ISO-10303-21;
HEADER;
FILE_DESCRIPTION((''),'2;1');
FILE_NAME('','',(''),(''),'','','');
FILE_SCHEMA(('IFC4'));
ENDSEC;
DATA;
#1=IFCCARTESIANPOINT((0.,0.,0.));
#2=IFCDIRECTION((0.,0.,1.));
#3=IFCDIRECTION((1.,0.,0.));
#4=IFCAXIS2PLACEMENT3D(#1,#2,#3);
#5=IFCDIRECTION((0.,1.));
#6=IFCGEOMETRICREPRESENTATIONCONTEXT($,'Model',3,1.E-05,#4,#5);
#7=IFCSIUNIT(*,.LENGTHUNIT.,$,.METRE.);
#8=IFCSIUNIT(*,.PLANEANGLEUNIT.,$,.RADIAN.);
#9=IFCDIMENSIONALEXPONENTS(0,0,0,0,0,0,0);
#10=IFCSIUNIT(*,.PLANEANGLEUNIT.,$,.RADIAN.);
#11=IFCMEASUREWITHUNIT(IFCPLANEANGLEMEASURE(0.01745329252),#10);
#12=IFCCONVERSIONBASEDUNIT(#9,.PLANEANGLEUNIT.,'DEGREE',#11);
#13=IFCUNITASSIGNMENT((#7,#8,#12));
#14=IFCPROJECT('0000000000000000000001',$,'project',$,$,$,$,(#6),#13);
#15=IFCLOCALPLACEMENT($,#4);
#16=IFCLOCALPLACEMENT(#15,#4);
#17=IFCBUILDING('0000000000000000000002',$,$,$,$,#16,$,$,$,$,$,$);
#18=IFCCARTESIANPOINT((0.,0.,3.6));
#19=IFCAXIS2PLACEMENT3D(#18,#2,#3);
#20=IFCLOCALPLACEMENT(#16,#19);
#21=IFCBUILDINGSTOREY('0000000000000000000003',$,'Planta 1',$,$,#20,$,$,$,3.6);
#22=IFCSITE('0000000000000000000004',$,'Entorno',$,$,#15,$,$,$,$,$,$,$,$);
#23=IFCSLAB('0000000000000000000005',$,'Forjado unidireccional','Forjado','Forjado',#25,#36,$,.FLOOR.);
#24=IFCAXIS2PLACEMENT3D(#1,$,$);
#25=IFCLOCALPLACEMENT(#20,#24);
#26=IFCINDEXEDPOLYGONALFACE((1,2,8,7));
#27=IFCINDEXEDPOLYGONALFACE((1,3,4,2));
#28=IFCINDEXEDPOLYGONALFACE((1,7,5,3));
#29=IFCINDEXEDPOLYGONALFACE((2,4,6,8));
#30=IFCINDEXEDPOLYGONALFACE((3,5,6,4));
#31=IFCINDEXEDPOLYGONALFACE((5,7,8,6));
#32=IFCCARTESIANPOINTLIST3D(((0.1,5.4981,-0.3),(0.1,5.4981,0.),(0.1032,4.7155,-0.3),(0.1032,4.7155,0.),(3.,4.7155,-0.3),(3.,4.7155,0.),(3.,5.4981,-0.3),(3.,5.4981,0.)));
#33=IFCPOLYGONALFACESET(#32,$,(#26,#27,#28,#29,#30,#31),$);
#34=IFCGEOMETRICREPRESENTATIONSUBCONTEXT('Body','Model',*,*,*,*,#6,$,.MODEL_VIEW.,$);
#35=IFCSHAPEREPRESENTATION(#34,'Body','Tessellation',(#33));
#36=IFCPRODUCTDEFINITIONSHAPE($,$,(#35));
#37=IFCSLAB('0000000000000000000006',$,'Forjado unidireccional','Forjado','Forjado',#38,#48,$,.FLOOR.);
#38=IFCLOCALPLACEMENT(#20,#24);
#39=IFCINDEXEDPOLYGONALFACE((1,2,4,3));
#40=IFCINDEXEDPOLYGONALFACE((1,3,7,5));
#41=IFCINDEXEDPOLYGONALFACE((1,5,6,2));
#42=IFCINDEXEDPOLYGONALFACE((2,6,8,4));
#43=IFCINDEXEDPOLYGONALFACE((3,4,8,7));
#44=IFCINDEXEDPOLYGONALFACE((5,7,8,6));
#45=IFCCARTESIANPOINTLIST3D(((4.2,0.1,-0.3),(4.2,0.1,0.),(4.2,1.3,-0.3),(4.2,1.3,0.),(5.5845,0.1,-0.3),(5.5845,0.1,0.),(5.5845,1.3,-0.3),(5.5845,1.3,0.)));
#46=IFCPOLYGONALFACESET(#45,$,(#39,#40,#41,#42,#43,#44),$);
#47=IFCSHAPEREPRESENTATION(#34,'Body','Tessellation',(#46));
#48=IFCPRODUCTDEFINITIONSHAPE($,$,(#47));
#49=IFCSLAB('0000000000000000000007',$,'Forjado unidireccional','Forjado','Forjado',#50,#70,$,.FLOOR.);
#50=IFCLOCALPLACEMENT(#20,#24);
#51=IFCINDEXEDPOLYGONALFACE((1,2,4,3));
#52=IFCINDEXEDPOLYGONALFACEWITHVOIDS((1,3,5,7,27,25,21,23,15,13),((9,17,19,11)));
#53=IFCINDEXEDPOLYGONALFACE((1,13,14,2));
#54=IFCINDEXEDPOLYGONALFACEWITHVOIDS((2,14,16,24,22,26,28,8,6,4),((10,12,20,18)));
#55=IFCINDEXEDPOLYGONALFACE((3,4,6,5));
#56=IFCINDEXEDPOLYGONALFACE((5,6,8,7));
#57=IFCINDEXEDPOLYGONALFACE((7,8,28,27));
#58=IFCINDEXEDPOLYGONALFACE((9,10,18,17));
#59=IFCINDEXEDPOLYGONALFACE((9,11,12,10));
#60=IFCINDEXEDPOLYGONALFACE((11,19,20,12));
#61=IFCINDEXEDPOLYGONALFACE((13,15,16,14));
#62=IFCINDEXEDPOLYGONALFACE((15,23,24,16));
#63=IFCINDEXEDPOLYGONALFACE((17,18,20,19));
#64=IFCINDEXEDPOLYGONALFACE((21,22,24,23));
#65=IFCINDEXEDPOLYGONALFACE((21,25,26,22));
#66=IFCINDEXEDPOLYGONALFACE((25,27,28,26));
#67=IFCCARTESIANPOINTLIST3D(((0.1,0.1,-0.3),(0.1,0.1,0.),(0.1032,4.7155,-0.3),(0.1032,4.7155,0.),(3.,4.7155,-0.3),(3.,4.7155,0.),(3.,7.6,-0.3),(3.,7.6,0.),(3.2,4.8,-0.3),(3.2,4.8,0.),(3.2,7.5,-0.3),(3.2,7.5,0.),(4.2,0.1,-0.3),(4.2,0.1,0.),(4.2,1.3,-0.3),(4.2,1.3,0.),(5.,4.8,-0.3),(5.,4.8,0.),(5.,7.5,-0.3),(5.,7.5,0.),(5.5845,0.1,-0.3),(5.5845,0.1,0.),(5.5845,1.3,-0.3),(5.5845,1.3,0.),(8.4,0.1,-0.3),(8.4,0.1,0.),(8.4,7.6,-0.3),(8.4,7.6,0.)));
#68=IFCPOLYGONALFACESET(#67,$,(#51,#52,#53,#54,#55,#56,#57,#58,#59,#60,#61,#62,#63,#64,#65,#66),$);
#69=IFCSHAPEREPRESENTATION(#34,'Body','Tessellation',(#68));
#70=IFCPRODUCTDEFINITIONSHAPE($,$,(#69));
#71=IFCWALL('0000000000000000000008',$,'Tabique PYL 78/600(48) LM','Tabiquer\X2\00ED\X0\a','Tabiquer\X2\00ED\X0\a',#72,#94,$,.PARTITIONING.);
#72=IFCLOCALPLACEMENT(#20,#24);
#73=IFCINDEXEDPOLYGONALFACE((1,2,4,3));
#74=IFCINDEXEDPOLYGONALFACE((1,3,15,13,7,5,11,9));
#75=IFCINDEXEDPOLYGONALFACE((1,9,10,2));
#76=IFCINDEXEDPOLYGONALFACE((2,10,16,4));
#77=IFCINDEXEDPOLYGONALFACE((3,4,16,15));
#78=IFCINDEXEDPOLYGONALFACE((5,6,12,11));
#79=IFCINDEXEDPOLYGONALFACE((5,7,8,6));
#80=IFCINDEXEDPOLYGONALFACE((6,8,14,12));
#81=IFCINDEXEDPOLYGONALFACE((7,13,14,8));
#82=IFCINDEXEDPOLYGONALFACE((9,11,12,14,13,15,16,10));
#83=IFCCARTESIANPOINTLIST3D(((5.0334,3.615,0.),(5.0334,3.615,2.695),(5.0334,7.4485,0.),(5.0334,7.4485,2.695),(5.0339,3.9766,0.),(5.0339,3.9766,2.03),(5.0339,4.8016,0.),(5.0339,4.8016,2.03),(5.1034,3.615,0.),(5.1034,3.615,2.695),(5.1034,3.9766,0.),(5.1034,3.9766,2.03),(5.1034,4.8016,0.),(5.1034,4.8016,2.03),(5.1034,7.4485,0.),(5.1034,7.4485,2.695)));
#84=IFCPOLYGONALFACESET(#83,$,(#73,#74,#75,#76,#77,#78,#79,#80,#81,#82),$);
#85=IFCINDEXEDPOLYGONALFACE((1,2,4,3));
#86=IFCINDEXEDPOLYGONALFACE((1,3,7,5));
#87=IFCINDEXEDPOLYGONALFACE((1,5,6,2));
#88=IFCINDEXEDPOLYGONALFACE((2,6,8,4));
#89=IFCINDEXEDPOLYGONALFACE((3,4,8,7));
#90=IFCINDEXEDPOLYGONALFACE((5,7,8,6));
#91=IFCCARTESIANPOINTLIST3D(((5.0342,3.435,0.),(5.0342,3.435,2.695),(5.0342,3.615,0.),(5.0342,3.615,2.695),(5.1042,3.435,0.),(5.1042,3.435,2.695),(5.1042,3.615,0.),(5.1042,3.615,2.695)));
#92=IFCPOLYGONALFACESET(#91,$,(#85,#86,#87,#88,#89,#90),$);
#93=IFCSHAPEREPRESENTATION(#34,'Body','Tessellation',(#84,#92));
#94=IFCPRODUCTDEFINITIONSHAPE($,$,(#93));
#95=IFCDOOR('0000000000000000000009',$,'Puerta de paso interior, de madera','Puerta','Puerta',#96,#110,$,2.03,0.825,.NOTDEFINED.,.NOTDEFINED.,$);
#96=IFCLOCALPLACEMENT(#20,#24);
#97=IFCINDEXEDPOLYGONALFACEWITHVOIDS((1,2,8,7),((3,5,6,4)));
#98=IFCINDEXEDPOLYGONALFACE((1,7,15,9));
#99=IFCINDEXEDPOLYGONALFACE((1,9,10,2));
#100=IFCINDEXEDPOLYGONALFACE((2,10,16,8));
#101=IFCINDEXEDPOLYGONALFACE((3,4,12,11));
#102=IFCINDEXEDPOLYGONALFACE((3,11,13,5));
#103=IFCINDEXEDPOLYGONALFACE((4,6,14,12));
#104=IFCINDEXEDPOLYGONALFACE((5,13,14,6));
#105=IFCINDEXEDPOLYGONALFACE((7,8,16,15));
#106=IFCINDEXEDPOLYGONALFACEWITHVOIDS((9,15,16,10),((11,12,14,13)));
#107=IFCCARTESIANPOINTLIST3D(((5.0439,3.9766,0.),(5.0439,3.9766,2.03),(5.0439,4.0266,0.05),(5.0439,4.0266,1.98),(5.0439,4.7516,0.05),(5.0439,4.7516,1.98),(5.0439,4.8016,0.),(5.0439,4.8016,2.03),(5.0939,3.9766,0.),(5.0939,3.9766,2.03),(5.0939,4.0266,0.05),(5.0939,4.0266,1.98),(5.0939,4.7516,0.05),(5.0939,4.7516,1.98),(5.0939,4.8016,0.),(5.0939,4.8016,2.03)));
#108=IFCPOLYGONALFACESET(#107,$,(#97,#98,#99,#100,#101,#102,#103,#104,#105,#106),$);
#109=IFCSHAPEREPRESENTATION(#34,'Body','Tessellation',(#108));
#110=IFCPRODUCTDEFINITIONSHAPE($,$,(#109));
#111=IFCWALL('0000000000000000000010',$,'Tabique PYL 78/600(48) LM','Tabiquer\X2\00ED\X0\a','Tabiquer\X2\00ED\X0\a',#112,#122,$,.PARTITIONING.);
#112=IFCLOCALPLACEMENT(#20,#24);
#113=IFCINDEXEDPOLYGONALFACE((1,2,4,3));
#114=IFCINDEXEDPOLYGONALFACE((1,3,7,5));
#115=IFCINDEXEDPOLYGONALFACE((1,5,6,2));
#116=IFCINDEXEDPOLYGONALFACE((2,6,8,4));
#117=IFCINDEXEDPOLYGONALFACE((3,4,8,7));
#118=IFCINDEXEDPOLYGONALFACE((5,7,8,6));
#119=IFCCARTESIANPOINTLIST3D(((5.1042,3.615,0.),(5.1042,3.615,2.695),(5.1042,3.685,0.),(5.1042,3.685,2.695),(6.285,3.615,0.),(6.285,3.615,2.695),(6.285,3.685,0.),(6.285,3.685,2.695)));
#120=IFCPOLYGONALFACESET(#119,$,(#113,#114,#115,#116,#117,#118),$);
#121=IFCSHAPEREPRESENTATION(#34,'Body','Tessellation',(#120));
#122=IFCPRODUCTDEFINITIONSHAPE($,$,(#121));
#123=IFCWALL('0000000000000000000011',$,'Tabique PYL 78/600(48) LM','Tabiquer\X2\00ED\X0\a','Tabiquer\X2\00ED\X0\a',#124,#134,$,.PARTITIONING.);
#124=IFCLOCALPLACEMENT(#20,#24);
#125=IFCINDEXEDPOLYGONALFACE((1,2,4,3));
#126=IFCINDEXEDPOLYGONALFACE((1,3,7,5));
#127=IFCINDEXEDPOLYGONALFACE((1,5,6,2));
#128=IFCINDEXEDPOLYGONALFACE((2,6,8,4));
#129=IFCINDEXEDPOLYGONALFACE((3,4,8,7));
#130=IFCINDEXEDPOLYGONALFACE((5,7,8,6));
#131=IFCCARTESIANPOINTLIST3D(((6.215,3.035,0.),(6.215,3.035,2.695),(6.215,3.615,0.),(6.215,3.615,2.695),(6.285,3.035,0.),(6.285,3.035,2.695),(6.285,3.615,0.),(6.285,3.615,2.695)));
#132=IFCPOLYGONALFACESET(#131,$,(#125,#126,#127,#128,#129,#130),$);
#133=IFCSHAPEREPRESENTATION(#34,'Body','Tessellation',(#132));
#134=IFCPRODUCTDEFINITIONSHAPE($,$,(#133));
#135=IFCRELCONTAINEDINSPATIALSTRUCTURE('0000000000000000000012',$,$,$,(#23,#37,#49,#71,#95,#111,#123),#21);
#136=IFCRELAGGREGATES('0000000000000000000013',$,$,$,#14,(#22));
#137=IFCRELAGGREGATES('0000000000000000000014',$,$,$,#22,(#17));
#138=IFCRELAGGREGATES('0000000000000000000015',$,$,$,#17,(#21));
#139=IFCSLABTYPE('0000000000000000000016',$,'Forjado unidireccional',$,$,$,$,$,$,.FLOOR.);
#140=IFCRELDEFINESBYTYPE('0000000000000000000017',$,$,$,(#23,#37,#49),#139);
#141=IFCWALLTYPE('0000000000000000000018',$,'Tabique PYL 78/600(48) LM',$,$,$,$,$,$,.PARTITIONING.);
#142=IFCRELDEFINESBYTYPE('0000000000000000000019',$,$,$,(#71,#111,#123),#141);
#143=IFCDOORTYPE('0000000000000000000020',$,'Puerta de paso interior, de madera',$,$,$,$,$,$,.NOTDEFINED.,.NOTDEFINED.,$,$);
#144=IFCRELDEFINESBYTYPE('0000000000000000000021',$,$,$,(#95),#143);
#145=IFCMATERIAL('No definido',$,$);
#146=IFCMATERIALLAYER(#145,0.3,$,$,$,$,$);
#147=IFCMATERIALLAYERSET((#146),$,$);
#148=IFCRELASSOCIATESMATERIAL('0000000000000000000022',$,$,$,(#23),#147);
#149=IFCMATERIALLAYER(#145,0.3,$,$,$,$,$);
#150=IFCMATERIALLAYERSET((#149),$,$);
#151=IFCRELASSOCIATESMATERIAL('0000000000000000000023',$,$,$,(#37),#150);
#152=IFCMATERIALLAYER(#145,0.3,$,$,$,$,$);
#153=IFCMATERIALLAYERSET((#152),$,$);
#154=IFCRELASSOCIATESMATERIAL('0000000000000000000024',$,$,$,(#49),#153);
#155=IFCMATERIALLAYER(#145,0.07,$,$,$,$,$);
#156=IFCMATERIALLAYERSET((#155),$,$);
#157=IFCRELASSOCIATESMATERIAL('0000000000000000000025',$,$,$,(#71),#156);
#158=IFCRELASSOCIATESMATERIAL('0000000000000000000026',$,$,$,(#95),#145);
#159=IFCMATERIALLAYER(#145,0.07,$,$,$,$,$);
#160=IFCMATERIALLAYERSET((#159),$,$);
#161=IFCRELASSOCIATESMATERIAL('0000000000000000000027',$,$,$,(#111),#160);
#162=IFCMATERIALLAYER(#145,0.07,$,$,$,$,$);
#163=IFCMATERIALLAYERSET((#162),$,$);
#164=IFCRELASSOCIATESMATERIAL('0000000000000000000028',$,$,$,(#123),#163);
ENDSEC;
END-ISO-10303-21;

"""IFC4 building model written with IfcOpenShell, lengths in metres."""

from ifc_helpers import new_model, entity, si_unit, converted_unit, direction, frame, origin_with_axes, origin_2d_with_axis, place, context, subcontext, project, spatial, polyline, rectangle, hollow_rectangle, outline, extrude, shape, material, layer, layer_set, layer_usage, type_object, element, fill, save


model = new_model("IFC4")

# Units and contexts
model_context = context("Model", 3, precision=1e-05, world=origin_with_axes(), true_north=direction((0.0, 1.0)))
body_context = subcontext(model_context, "Body", "Model", "MODEL_VIEW")
footprint_context = subcontext(model_context, "FootPrint", "Model", "MODEL_VIEW")
ifc_project = project(units=[si_unit("LENGTHUNIT", "METRE"), si_unit("PLANEANGLEUNIT", "RADIAN"), converted_unit("PLANEANGLEUNIT", "DEGREE", entity("IfcPlaneAngleMeasure", 0.01745329252), si_unit("PLANEANGLEUNIT", "RADIAN"), dimensions=[0, 0, 0, 0, 0, 0, 0])], contexts=[model_context])

# Site, building, storey
site_placement = place(None, origin_with_axes())
site = spatial("IfcSite", under=ifc_project, at=site_placement, Name="Entorno")
building_placement = place(site_placement, origin_with_axes())
building = spatial("IfcBuilding", under=site, at=building_placement)
storey_placement = place(building_placement, frame((0.0, 0.0, 3.6), z_axis=(0.0, 0.0, 1.0), x_axis=(1.0, 0.0, 0.0)))
storey = spatial("IfcBuildingStorey", under=building, at=storey_placement, Name="Planta 1", Elevation=3.6)

# Slabs
ifc_material = material(Name="No definido")
ifc_layer_1 = layer(ifc_material, 0.3)
ifc_layer_set_1 = layer_set([ifc_layer_1])
ifc_layer_usage_1 = layer_usage(ifc_layer_set_1, "AXIS3", "POSITIVE", 0.0)
slab_type = type_object("IfcSlabType", Name="Forjado unidireccional", PredefinedType="FLOOR")
slab_1_placement = place(storey_placement, frame((3.0, 5.4981, -0.3), z_axis=(0.0, 0.0, 1.0), x_axis=(1.0, 0.0, 0.0)))
element("IfcSlab", 1, at=slab_1_placement, inside=storey, type_object=slab_type, material=ifc_layer_usage_1, Name="Forjado unidireccional", Description="Forjado", ObjectType="Forjado", PredefinedType="FLOOR", context=body_context, shape_type="SweptSolid", body=[
    extrude(outline(polyline([(0.0, 0.0), (-2.9, 0.0), (-2.8968, -0.7826), (0.0, -0.7826), (0.0, 0.0)])), origin_with_axes(), (0.0, 0.0, 1.0), 0.3),
])
ifc_layer_2 = layer(ifc_material, 0.3)
ifc_layer_set_2 = layer_set([ifc_layer_2])
ifc_layer_usage_2 = layer_usage(ifc_layer_set_2, "AXIS3", "POSITIVE", 0.0)
slab_2_placement = place(storey_placement, frame((5.5845, 0.1, -0.3), z_axis=(0.0, 0.0, 1.0), x_axis=(1.0, 0.0, 0.0)))
element("IfcSlab", 2, at=slab_2_placement, inside=storey, type_object=slab_type, material=ifc_layer_usage_2, Name="Forjado unidireccional", Description="Forjado", ObjectType="Forjado", PredefinedType="FLOOR", context=body_context, shape_type="SweptSolid", body=[
    extrude(outline(polyline([(0.0, 0.0), (0.0, 1.2), (-1.3845, 1.2), (-1.3845, 0.0), (0.0, 0.0)])), origin_with_axes(), (0.0, 0.0, 1.0), 0.3),
])

# Slab, opening
ifc_layer_3 = layer(ifc_material, 0.3)
ifc_layer_set_3 = layer_set([ifc_layer_3])
ifc_layer_usage_3 = layer_usage(ifc_layer_set_3, "AXIS3", "POSITIVE", 0.0)
slab_3_placement = place(storey_placement, frame((5.5845, 0.1, -0.3), z_axis=(0.0, 0.0, 1.0), x_axis=(1.0, 0.0, 0.0)))
slab_3 = element("IfcSlab", 3, at=slab_3_placement, inside=storey, type_object=slab_type, material=ifc_layer_usage_3, Name="Forjado unidireccional", Description="Forjado", ObjectType="Forjado", PredefinedType="FLOOR", context=body_context, shape_type="SweptSolid", body=[
    extrude(outline(polyline([(0.0, 0.0), (2.8155, 0.0), (2.8155, 7.5), (-2.5845, 7.5), (-2.5845, 4.6155), (-5.4813, 4.6155), (-5.4845, 0.0), (-1.3845, 0.0), (-1.3845, 1.2), (0.0, 1.2), (0.0, 0.0)])), origin_with_axes(), (0.0, 0.0, 1.0), 0.3),
])
opening_1_placement = place(slab_3_placement, frame((-2.3845, 4.7, -0.01), z_axis=(0.0, 0.0, 1.0), x_axis=(1.0, 0.0, 0.0)))
element("IfcOpeningElement", 4, at=opening_1_placement, cuts=slab_3, ObjectType="No definido", PredefinedType="OPENING", context=body_context, shape_type="SweptSolid", body=[
    extrude(outline(polyline([(0.0, 0.0), (1.8, 0.0), (1.8, 2.7), (0.0, 2.7), (0.0, 0.0)])), origin_with_axes(), (0.0, 0.0, 1.0), 0.32),
])

# Wall, opening, door
ifc_layer_4 = layer(ifc_material, 0.07)
ifc_layer_set_4 = layer_set([ifc_layer_4])
ifc_layer_usage_4 = layer_usage(ifc_layer_set_4, "AXIS2", "POSITIVE", -0.035)
wall_type_1 = type_object("IfcWallType", Name="Tabique PYL 78/600(48) LM", PredefinedType="PARTITIONING")
wall_1_placement = place(storey_placement, frame((5.0692, 7.6, 0.0), z_axis=(0.0, 0.0, 1.0), x_axis=(0.0, -1.0, 0.0)))
cartesian_point_1 = entity("IfcCartesianPoint", [-1.9167, -1.3475])
cartesian_point_2 = entity("IfcCartesianPoint", [-1.9167, -1.3475])
cartesian_point_3 = entity("IfcCartesianPoint", [-0.09, -1.3475])
cartesian_point_4 = entity("IfcCartesianPoint", [-0.09, -1.3475])
wall_1 = element("IfcWall", 5, at=wall_1_placement, inside=storey, type_object=wall_type_1, material=ifc_layer_usage_4, Name="Tabique PYL 78/600(48) LM", Description="Tabiquería", ObjectType="Tabiquería", PredefinedType="PARTITIONING", context=body_context, shape_type="SolidModel", body=[
    entity("IfcExtrudedAreaSolidTapered", entity("IfcArbitraryClosedProfileDef", "AREA", None, entity("IfcPolyline", [cartesian_point_1, entity("IfcCartesianPoint", [1.9167, -1.3475]), entity("IfcCartesianPoint", [1.9167, 1.3475]), entity("IfcCartesianPoint", [-1.9167, 1.3475]), cartesian_point_1])), entity("IfcAxis2Placement3D", entity("IfcCartesianPoint", [2.0682, 0.0342, 1.3475]), entity("IfcDirection", [0.0, -1.0, 0.0]), entity("IfcDirection", [1.0, 0.0, 0.0])), entity("IfcDirection", [0.0, 0.0, 1.0]), 0.07, entity("IfcArbitraryClosedProfileDef", "AREA", None, entity("IfcPolyline", [cartesian_point_2, entity("IfcCartesianPoint", [1.9167, -1.3475]), entity("IfcCartesianPoint", [1.9167, 1.3475]), entity("IfcCartesianPoint", [-1.9167, 1.3475]), cartesian_point_2]))),
    entity("IfcExtrudedAreaSolidTapered", entity("IfcArbitraryClosedProfileDef", "AREA", None, entity("IfcPolyline", [cartesian_point_3, entity("IfcCartesianPoint", [0.09, -1.3475]), entity("IfcCartesianPoint", [0.09, 1.3475]), entity("IfcCartesianPoint", [-0.09, 1.3475]), cartesian_point_3])), entity("IfcAxis2Placement3D", entity("IfcCartesianPoint", [4.075, 0.035, 1.3475]), entity("IfcDirection", [0.0, -1.0, 0.0]), entity("IfcDirection", [1.0, 0.0, 0.0])), entity("IfcDirection", [0.0, 0.0, 1.0]), 0.07, entity("IfcArbitraryClosedProfileDef", "AREA", None, entity("IfcPolyline", [cartesian_point_4, entity("IfcCartesianPoint", [0.09, -1.3475]), entity("IfcCartesianPoint", [0.09, 1.3475]), entity("IfcCartesianPoint", [-0.09, 1.3475]), cartesian_point_4]))),
])
opening_2_placement = place(wall_1_placement, frame((3.2109, -0.0003, 1.015), z_axis=(0.0, 0.0, 1.0), x_axis=(1.0, 0.0, 0.0)))
cartesian_point_5 = entity("IfcCartesianPoint", [-0.4125, -0.035])
opening_2 = element("IfcOpeningElement", 6, at=opening_2_placement, cuts=wall_1, ObjectType="No definido", PredefinedType="OPENING", shapes=[
    shape(body_context, "Body", "SweptSolid", [extrude(rectangle(XDim=2.03, YDim=0.825, at=origin_2d_with_axis()), frame((0.0, -0.035, 0.0), z_axis=(0.0, 1.0, 0.0), x_axis=(0.0, 0.0, 1.0)), (0.0, 0.0, 1.0), 0.07)]),
    shape(footprint_context, "FootPrint", "GeometricCurveSet", [entity("IfcGeometricCurveSet", [entity("IfcPolyline", [cartesian_point_5, entity("IfcCartesianPoint", [0.4125, -0.035]), entity("IfcCartesianPoint", [0.4125, 0.035]), entity("IfcCartesianPoint", [-0.4125, 0.035]), cartesian_point_5])])]),
])
door_type = type_object("IfcDoorType", Name="Puerta de paso interior, de madera", OperationType="NOTDEFINED", PredefinedType="NOTDEFINED")
door_1_placement = place(opening_2_placement, origin_with_axes())
door_1 = element("IfcDoor", 7, at=door_1_placement, inside=storey, type_object=door_type, material=ifc_material, Name="Puerta de paso interior, de madera", Description="Puerta", ObjectType="Puerta", OperationType="NOTDEFINED", OverallHeight=2.03, OverallWidth=0.825, PredefinedType="NOTDEFINED", context=body_context, shape_type="SweptSolid", body=[
    extrude(hollow_rectangle(XDim=0.825, YDim=2.03, WallThickness=0.05, InnerFilletRadius=0.0, OuterFilletRadius=0.0, at=origin_2d_with_axis()), frame((0.0, 0.025, 0.0), z_axis=(0.0, -1.0, 0.0), x_axis=(1.0, 0.0, 0.0)), (0.0, 0.0, 1.0), 0.05),
])
fill(opening_2, door_1)

# Walls
ifc_layer_5 = layer(ifc_material, 0.07)
ifc_layer_set_5 = layer_set([ifc_layer_5])
ifc_layer_usage_5 = layer_usage(ifc_layer_set_5, "AXIS2", "POSITIVE", -0.035)
wall_2_placement = place(storey_placement, frame((5.0692, 3.65, 0.0), z_axis=(0.0, 0.0, 1.0), x_axis=(1.0, 0.0, 0.0)))
cartesian_point_6 = entity("IfcCartesianPoint", [-0.5904, -1.3475])
cartesian_point_7 = entity("IfcCartesianPoint", [-0.5904, -1.3475])
element("IfcWall", 8, at=wall_2_placement, inside=storey, type_object=wall_type_1, material=ifc_layer_usage_5, Name="Tabique PYL 78/600(48) LM", Description="Tabiquería", ObjectType="Tabiquería", PredefinedType="PARTITIONING", context=body_context, shape_type="SolidModel", body=[
    entity("IfcExtrudedAreaSolidTapered", entity("IfcArbitraryClosedProfileDef", "AREA", None, entity("IfcPolyline", [cartesian_point_6, entity("IfcCartesianPoint", [0.5904, -1.3475]), entity("IfcCartesianPoint", [0.5904, 1.3475]), entity("IfcCartesianPoint", [-0.5904, 1.3475]), cartesian_point_6])), entity("IfcAxis2Placement3D", entity("IfcCartesianPoint", [0.6254, 0.035, 1.3475]), entity("IfcDirection", [0.0, -1.0, 0.0]), entity("IfcDirection", [1.0, 0.0, 0.0])), entity("IfcDirection", [0.0, 0.0, 1.0]), 0.07, entity("IfcArbitraryClosedProfileDef", "AREA", None, entity("IfcPolyline", [cartesian_point_7, entity("IfcCartesianPoint", [0.5904, -1.3475]), entity("IfcCartesianPoint", [0.5904, 1.3475]), entity("IfcCartesianPoint", [-0.5904, 1.3475]), cartesian_point_7]))),
])
ifc_layer_6 = layer(ifc_material, 0.07)
ifc_layer_set_6 = layer_set([ifc_layer_6])
ifc_layer_usage_6 = layer_usage(ifc_layer_set_6, "AXIS2", "POSITIVE", -0.035)
wall_3_placement = place(storey_placement, frame((6.25, 3.65, 0.0), z_axis=(0.0, 0.0, 1.0), x_axis=(0.0, -1.0, 0.0)))
cartesian_point_8 = entity("IfcCartesianPoint", [-0.29, -1.3475])
cartesian_point_9 = entity("IfcCartesianPoint", [-0.29, -1.3475])
element("IfcWall", 9, at=wall_3_placement, inside=storey, type_object=wall_type_1, material=ifc_layer_usage_6, Name="Tabique PYL 78/600(48) LM", Description="Tabiquería", ObjectType="Tabiquería", PredefinedType="PARTITIONING", context=body_context, shape_type="SolidModel", body=[
    entity("IfcExtrudedAreaSolidTapered", entity("IfcArbitraryClosedProfileDef", "AREA", None, entity("IfcPolyline", [cartesian_point_8, entity("IfcCartesianPoint", [0.29, -1.3475]), entity("IfcCartesianPoint", [0.29, 1.3475]), entity("IfcCartesianPoint", [-0.29, 1.3475]), cartesian_point_8])), entity("IfcAxis2Placement3D", entity("IfcCartesianPoint", [0.325, 0.035, 1.3475]), entity("IfcDirection", [0.0, -1.0, 0.0]), entity("IfcDirection", [1.0, 0.0, 0.0])), entity("IfcDirection", [0.0, 0.0, 1.0]), 0.07, entity("IfcArbitraryClosedProfileDef", "AREA", None, entity("IfcPolyline", [cartesian_point_9, entity("IfcCartesianPoint", [0.29, -1.3475]), entity("IfcCartesianPoint", [0.29, 1.3475]), entity("IfcCartesianPoint", [-0.29, 1.3475]), cartesian_point_9]))),
])

save(model, "model.ifc")
